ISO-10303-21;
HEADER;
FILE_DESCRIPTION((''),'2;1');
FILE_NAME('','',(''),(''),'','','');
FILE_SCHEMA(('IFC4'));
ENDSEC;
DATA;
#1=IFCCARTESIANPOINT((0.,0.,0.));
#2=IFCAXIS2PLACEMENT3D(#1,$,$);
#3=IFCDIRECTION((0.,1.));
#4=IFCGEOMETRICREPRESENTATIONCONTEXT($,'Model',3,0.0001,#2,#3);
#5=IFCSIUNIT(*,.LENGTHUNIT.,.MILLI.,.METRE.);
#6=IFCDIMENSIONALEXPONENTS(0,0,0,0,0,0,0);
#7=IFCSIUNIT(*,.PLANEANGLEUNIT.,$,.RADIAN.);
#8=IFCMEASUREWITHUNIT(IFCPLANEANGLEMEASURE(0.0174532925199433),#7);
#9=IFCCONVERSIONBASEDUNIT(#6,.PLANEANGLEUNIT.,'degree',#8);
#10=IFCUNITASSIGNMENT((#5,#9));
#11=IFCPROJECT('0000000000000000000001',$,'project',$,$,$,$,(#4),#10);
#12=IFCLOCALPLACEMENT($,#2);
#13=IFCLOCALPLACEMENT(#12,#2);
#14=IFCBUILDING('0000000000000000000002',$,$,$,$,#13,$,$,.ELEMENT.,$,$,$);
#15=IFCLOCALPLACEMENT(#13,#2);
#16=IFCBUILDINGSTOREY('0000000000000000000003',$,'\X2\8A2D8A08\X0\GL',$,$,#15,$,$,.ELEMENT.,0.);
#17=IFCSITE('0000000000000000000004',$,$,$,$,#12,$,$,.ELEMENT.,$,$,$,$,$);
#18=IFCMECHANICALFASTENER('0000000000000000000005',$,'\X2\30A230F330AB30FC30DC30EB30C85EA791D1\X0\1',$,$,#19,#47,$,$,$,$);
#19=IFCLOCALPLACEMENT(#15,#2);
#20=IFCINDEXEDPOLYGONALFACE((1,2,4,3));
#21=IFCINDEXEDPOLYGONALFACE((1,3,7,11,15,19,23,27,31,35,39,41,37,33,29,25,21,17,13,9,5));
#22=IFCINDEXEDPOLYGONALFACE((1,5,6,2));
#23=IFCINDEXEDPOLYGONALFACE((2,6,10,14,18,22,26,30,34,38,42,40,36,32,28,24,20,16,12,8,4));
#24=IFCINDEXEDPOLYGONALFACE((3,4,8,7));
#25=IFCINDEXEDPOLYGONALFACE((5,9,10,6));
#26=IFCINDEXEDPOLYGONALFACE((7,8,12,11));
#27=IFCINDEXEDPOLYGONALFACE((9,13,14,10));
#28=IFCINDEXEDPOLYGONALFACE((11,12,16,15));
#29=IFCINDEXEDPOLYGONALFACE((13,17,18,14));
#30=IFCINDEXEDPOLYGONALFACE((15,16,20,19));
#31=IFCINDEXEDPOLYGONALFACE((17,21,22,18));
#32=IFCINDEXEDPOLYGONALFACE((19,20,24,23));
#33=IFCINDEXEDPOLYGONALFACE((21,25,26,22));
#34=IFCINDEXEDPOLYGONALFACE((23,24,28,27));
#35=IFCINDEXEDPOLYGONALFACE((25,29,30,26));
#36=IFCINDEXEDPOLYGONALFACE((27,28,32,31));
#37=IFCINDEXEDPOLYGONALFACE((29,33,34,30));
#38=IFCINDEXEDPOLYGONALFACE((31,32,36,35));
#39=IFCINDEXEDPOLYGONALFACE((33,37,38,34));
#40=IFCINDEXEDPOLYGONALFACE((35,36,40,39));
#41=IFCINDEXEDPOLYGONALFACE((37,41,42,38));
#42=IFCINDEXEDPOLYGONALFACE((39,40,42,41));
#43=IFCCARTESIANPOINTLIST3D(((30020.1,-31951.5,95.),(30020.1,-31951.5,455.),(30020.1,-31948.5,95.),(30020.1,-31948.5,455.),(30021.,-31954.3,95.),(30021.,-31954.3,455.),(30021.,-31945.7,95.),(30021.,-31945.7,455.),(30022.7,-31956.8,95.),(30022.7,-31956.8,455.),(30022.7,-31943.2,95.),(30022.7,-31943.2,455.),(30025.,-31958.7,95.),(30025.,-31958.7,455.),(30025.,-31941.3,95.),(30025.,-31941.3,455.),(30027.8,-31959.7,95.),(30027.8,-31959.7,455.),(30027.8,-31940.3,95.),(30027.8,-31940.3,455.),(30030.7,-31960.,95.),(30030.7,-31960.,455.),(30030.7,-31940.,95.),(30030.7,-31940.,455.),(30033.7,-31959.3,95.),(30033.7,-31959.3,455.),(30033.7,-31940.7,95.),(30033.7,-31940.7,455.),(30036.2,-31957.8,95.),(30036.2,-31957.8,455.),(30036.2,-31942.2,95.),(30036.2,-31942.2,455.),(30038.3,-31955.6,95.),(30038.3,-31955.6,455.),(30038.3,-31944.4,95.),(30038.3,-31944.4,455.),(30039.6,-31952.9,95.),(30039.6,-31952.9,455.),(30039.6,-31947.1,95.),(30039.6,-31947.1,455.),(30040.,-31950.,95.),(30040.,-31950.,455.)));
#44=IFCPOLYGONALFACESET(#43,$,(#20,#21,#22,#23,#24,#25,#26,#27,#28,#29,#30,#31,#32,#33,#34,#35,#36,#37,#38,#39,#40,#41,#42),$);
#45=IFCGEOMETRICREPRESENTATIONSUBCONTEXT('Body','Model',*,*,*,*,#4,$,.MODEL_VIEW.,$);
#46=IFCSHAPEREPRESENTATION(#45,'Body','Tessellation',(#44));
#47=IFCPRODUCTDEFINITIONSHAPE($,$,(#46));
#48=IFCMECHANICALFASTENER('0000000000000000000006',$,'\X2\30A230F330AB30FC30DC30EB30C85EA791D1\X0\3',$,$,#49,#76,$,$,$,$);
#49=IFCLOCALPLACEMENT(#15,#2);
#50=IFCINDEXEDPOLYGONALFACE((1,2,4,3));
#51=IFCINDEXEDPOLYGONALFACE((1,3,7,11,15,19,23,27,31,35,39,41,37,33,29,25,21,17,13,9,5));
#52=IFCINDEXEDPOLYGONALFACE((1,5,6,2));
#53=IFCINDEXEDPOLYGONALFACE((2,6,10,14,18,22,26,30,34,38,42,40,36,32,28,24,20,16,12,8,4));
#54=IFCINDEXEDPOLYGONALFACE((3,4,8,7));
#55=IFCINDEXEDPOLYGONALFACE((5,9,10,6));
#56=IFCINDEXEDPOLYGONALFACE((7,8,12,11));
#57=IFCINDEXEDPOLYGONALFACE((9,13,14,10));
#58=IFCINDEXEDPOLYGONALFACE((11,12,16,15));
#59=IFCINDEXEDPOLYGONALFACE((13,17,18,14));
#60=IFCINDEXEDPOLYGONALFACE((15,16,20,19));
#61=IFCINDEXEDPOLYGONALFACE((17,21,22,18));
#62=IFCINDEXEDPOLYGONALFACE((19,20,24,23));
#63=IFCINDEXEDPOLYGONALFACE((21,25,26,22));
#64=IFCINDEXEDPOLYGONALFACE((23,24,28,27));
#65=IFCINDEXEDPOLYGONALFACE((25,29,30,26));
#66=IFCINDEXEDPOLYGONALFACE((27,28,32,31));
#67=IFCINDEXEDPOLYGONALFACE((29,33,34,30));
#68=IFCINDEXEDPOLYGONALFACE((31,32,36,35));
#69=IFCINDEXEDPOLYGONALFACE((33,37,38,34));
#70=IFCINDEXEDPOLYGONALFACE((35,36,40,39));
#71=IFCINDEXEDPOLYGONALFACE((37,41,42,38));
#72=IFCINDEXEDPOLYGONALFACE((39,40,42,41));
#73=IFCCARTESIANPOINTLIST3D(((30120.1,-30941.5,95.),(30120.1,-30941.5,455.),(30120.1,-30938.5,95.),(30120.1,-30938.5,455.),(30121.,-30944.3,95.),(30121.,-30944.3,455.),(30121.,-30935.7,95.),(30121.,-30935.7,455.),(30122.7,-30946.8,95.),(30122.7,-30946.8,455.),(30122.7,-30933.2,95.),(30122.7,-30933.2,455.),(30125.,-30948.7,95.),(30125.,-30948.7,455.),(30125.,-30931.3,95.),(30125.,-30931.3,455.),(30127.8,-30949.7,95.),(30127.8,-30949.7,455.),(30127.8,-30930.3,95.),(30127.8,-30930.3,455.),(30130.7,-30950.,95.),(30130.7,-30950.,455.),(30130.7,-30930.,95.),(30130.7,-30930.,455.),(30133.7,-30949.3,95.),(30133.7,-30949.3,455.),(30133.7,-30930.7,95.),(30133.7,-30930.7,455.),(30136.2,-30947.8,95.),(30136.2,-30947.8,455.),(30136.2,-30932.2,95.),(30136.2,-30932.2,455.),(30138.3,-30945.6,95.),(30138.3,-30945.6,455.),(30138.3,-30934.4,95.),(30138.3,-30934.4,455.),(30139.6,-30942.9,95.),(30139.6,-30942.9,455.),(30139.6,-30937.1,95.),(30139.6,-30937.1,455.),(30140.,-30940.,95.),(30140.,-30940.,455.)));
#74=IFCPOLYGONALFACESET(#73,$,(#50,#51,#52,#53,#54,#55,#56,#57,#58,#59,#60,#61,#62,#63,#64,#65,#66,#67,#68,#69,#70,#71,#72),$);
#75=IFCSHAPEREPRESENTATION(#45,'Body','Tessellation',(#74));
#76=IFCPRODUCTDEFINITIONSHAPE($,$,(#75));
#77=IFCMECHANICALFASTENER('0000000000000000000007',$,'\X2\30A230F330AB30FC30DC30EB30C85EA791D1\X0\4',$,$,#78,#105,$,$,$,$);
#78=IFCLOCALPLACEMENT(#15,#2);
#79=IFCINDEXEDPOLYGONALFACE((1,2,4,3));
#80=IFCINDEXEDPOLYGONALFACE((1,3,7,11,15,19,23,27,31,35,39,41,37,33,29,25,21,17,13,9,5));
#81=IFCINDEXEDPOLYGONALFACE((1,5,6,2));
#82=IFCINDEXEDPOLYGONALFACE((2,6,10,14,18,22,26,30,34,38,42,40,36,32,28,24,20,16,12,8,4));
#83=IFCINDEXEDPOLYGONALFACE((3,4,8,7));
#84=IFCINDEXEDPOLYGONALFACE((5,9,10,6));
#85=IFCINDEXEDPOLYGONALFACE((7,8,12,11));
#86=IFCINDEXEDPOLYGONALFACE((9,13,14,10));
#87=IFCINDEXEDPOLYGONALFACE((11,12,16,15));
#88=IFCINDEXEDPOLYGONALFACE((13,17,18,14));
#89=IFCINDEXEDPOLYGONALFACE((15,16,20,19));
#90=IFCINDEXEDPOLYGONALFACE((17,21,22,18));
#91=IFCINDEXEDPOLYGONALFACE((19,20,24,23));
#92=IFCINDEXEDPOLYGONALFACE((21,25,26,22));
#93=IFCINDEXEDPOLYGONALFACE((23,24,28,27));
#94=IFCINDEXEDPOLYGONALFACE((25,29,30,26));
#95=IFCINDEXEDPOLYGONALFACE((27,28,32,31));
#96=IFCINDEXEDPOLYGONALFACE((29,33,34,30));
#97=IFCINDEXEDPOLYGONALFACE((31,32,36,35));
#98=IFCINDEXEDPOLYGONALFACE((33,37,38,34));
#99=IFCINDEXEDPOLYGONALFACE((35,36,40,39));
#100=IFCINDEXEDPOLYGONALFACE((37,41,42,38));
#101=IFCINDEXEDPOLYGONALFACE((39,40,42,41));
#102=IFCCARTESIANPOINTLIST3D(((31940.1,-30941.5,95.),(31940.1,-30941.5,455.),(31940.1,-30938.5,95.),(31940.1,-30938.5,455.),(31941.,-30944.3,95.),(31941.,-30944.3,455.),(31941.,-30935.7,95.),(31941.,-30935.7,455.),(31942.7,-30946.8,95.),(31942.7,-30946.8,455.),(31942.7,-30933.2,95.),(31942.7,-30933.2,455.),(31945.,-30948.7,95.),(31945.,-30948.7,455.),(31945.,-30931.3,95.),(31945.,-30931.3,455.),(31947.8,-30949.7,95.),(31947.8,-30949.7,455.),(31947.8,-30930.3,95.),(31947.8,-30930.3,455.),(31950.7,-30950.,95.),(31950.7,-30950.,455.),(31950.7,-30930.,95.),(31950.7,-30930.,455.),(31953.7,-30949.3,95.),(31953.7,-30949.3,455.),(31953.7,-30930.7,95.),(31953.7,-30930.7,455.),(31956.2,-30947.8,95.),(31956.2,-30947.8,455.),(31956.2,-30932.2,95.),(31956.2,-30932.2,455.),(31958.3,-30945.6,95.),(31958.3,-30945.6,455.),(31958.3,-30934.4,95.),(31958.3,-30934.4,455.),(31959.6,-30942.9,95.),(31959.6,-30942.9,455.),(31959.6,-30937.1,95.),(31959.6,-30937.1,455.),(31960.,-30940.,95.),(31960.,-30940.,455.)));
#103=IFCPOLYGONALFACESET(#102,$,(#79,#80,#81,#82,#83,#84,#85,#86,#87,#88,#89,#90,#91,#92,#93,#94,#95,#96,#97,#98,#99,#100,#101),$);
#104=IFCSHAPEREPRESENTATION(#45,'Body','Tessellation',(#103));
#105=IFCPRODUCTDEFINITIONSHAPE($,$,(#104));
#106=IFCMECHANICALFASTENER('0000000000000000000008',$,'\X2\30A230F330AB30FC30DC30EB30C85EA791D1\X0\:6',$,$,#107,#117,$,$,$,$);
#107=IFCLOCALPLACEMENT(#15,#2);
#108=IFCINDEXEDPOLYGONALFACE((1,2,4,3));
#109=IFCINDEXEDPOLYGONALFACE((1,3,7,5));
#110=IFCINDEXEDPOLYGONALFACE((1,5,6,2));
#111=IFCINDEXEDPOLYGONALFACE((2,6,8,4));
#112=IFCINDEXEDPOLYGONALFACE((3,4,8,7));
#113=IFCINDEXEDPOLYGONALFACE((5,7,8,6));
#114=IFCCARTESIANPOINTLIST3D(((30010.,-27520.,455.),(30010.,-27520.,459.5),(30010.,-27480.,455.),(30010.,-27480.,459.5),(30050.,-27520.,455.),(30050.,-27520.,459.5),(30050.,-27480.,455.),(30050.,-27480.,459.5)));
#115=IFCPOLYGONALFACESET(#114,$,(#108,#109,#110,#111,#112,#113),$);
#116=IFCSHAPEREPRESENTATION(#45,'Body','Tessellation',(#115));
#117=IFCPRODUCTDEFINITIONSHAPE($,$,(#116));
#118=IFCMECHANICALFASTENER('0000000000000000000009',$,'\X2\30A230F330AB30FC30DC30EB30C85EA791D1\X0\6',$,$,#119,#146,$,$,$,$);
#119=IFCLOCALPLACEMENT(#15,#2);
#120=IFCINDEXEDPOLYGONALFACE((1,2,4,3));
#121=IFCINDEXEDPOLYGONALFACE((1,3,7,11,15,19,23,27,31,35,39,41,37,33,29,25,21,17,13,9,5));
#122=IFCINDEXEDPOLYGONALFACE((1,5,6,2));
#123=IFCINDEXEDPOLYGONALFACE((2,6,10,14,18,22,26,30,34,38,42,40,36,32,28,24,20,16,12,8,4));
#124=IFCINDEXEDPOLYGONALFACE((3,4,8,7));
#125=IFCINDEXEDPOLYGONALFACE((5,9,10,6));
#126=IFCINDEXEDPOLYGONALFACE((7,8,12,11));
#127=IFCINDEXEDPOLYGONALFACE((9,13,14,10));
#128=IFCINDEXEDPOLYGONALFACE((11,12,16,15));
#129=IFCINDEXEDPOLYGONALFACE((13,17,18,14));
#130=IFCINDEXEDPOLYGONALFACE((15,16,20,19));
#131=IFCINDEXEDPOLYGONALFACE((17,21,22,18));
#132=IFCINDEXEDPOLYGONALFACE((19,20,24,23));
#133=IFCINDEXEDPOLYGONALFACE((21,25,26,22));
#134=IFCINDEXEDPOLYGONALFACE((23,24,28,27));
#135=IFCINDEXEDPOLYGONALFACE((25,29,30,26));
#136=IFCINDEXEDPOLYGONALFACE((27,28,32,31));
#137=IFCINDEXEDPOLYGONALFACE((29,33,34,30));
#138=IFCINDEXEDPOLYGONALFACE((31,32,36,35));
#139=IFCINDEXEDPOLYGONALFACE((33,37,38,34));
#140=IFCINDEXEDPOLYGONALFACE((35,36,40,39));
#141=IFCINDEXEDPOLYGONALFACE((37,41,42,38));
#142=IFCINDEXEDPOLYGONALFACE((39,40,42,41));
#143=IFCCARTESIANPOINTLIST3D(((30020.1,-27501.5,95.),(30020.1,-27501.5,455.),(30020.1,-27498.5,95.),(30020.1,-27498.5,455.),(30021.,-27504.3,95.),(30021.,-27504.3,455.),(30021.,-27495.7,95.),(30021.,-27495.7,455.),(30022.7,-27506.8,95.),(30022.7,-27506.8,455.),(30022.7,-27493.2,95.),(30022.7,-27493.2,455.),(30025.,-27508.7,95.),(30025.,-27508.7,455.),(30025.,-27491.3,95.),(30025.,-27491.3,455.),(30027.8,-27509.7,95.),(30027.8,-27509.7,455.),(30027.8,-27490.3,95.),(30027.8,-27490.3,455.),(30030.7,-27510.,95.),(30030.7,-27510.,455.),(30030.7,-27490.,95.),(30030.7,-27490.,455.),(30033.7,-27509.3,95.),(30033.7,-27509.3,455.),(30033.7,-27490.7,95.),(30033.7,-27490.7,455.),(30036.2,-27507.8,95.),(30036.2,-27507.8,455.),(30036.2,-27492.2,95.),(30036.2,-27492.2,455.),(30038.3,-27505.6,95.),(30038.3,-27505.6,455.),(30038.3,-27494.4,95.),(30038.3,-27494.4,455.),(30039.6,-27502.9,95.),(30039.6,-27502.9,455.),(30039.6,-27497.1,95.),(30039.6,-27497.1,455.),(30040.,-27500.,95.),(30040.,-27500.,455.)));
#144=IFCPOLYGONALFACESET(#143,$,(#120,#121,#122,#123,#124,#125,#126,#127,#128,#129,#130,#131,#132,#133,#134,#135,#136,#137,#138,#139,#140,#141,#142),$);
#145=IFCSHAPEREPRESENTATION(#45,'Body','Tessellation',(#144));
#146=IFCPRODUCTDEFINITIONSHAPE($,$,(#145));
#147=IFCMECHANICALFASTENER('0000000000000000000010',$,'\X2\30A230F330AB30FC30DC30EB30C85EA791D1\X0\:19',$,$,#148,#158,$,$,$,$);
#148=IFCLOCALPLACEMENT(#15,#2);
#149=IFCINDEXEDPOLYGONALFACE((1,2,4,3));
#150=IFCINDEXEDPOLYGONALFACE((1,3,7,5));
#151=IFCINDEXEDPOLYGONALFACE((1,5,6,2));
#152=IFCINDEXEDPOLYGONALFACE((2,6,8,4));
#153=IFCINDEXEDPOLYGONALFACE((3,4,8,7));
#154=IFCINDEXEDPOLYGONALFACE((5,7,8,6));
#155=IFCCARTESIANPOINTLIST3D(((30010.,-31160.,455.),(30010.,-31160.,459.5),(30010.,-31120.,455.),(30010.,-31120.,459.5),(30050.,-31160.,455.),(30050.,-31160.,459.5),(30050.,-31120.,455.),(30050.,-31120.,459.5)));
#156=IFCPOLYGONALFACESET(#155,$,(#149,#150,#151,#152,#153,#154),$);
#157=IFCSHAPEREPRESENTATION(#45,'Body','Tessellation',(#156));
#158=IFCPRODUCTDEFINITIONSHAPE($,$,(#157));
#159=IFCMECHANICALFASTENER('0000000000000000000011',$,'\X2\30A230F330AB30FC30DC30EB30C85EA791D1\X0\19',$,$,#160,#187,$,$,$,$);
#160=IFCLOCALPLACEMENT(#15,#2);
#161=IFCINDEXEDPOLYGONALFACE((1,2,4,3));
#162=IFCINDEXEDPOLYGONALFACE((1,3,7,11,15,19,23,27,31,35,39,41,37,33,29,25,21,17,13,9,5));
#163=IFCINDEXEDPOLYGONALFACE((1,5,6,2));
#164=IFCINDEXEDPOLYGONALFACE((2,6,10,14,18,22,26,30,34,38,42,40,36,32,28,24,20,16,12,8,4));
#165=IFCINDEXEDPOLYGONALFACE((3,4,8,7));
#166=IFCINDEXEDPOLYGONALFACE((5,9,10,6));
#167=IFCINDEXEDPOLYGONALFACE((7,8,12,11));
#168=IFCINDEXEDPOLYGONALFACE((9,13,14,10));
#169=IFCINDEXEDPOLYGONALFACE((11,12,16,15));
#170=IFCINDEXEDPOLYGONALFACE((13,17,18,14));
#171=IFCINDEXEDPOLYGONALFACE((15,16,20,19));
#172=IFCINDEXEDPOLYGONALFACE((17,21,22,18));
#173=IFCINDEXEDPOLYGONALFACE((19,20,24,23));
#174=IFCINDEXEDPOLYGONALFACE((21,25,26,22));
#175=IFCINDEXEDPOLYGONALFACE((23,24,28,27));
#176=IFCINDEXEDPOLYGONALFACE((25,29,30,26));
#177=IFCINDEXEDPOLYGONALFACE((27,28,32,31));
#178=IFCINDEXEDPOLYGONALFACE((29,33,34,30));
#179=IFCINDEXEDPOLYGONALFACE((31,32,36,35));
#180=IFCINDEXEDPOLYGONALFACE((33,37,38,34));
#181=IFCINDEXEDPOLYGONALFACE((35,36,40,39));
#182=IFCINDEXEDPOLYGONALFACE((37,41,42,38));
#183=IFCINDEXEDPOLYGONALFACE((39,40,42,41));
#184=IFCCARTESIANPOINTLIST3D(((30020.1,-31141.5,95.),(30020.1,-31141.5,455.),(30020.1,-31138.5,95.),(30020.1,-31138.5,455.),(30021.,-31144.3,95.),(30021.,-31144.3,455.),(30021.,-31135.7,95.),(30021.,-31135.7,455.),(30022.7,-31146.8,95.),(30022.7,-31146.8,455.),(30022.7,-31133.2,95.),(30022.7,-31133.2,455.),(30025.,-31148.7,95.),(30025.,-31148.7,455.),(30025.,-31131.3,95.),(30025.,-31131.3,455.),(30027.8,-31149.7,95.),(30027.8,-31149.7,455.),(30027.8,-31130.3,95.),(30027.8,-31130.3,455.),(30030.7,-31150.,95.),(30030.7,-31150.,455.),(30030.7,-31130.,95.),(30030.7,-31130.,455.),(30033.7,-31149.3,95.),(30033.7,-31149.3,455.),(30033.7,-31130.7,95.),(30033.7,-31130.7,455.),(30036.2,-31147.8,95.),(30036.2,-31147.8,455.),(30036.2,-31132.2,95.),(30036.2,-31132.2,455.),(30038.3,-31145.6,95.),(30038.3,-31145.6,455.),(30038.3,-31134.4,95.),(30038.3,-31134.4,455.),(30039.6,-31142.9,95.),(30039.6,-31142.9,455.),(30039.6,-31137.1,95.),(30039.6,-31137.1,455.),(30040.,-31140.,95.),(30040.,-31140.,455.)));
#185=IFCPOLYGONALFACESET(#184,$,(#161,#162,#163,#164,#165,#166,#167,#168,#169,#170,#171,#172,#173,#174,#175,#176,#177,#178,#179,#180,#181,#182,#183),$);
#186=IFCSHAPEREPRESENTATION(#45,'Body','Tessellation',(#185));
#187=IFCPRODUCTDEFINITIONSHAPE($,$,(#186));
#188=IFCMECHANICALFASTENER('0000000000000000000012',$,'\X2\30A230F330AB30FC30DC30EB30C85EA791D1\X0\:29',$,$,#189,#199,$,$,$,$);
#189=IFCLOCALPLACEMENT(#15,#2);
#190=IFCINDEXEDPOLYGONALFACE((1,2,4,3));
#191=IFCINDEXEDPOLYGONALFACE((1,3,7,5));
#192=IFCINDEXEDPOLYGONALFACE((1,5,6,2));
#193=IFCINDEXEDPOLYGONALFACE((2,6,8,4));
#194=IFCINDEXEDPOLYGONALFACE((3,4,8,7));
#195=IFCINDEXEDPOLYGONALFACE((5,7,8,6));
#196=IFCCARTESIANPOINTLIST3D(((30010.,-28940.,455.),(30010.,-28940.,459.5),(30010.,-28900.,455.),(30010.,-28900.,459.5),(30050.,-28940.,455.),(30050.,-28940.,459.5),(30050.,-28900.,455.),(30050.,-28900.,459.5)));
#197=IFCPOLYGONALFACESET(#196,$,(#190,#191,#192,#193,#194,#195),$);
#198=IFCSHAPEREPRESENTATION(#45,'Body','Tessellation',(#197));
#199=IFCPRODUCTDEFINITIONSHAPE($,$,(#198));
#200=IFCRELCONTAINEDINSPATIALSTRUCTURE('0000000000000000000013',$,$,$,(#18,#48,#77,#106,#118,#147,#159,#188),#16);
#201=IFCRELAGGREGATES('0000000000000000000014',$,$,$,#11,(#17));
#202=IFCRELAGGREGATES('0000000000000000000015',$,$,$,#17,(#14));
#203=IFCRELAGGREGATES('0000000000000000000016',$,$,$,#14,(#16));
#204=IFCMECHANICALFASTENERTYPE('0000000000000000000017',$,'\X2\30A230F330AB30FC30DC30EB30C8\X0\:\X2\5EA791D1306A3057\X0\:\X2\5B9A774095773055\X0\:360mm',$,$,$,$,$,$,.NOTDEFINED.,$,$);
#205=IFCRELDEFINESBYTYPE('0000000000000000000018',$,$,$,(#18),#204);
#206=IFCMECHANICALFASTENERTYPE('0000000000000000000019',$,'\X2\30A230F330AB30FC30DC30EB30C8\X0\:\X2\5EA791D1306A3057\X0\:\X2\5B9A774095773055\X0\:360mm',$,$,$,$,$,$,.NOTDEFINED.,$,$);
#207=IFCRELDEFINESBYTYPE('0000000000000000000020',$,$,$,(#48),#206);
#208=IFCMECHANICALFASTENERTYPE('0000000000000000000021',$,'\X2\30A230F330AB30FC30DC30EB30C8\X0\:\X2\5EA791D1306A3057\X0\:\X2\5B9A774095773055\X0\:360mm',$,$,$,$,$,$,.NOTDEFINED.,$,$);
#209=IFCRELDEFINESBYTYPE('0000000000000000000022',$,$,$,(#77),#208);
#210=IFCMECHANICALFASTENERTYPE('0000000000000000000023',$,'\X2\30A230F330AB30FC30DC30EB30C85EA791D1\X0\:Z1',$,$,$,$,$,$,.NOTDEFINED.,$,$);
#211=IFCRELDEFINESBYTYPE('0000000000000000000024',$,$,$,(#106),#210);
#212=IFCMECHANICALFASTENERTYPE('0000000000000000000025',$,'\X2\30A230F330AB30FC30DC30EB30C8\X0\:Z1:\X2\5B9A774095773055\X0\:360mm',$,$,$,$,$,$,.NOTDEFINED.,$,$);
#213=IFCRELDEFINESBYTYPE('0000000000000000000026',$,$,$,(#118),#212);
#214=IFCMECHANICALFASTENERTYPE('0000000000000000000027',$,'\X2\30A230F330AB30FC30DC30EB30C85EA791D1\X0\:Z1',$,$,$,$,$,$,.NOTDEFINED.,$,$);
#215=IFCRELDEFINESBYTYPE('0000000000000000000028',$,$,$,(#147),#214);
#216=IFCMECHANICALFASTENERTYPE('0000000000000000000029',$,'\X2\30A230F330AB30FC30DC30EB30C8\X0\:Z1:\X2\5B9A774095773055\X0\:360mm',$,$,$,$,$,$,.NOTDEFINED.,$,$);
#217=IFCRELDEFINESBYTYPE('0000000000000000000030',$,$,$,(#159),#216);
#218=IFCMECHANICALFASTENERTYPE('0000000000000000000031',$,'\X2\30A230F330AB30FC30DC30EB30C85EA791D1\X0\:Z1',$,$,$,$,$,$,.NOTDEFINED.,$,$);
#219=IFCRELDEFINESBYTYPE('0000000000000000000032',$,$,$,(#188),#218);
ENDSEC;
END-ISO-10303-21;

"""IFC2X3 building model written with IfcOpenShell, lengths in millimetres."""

from ifc_helpers import new_model, entity, si_unit, converted_unit, direction, frame, origin, origin_with_axes, origin_2d, place, context, subcontext, project, spatial, rectangle, circle, extrude, type_object, element, save


model = new_model("IFC2X3")

# Units and contexts
model_context = context("Model", 3, precision=0.0001, world=origin(), true_north=direction((0.0, 1.0)))
body_context = subcontext(model_context, "Body", "Model", "MODEL_VIEW")
ifc_project = project(units=[si_unit("LENGTHUNIT", "METRE", prefix="MILLI"), converted_unit("PLANEANGLEUNIT", "degree", entity("IfcPlaneAngleMeasure", 0.0174532925199433), si_unit("PLANEANGLEUNIT", "RADIAN"), dimensions=[0, 0, 0, 0, 0, 0, 0])], contexts=[model_context])

# Site, building, storey
site_placement = place(None, origin())
site = spatial("IfcSite", under=ifc_project, at=site_placement, CompositionType="ELEMENT")
building_placement = place(site_placement, origin())
building = spatial("IfcBuilding", under=site, at=building_placement, CompositionType="ELEMENT")
storey_placement = place(building_placement, origin())
storey = spatial("IfcBuildingStorey", under=building, at=storey_placement, Name="設計GL", CompositionType="ELEMENT", Elevation=0.0)

# Mechanical fasteners
mechanical_fastener_type_1 = type_object("IfcMechanicalFastenerType", Name="アンカーボルト:座金なし:定着長さ:360mm")
mechanical_fastener_1_placement = place(storey_placement, frame((30030.0, -31950.0, 95.0)))
element("IfcMechanicalFastener", 1, at=mechanical_fastener_1_placement, inside=storey, type_object=mechanical_fastener_type_1, Name="アンカーボルト座金1", context=body_context, shape_type="SweptSolid", body=[
    extrude(circle(Radius=10.0, at=origin_2d()), origin_with_axes(), (0.0, 0.0, 1.0), 360.0),
])
mechanical_fastener_type_2 = type_object("IfcMechanicalFastenerType", Name="アンカーボルト:座金なし:定着長さ:360mm")
mechanical_fastener_2_placement = place(storey_placement, frame((30130.0, -30940.0, 95.0)))
element("IfcMechanicalFastener", 2, at=mechanical_fastener_2_placement, inside=storey, type_object=mechanical_fastener_type_2, Name="アンカーボルト座金3", context=body_context, shape_type="SweptSolid", body=[
    extrude(circle(Radius=10.0, at=origin_2d()), origin_with_axes(), (0.0, 0.0, 1.0), 360.0),
])
mechanical_fastener_type_3 = type_object("IfcMechanicalFastenerType", Name="アンカーボルト:座金なし:定着長さ:360mm")
mechanical_fastener_3_placement = place(storey_placement, frame((31950.0, -30940.0, 95.0)))
element("IfcMechanicalFastener", 3, at=mechanical_fastener_3_placement, inside=storey, type_object=mechanical_fastener_type_3, Name="アンカーボルト座金4", context=body_context, shape_type="SweptSolid", body=[
    extrude(circle(Radius=10.0, at=origin_2d()), origin_with_axes(), (0.0, 0.0, 1.0), 360.0),
])
mechanical_fastener_type_4 = type_object("IfcMechanicalFastenerType", Name="アンカーボルト座金:Z1")
mechanical_fastener_4_placement = place(storey_placement, frame((30030.0, -27500.0, 455.0)))
element("IfcMechanicalFastener", 4, at=mechanical_fastener_4_placement, inside=storey, type_object=mechanical_fastener_type_4, Name="アンカーボルト座金:6", context=body_context, shape_type="SweptSolid", body=[
    extrude(rectangle(XDim=40.0, YDim=40.0, at=origin_2d()), origin_with_axes(), (0.0, 0.0, 1.0), 4.5),
])
mechanical_fastener_type_5 = type_object("IfcMechanicalFastenerType", Name="アンカーボルト:Z1:定着長さ:360mm")
mechanical_fastener_5_placement = place(storey_placement, frame((30030.0, -27500.0, 95.0)))
element("IfcMechanicalFastener", 5, at=mechanical_fastener_5_placement, inside=storey, type_object=mechanical_fastener_type_5, Name="アンカーボルト座金6", context=body_context, shape_type="SweptSolid", body=[
    extrude(circle(Radius=10.0, at=origin_2d()), origin_with_axes(), (0.0, 0.0, 1.0), 360.0),
])
mechanical_fastener_type_6 = type_object("IfcMechanicalFastenerType", Name="アンカーボルト座金:Z1")
mechanical_fastener_6_placement = place(storey_placement, frame((30030.0, -31140.0, 455.0)))
element("IfcMechanicalFastener", 6, at=mechanical_fastener_6_placement, inside=storey, type_object=mechanical_fastener_type_6, Name="アンカーボルト座金:19", context=body_context, shape_type="SweptSolid", body=[
    extrude(rectangle(XDim=40.0, YDim=40.0, at=origin_2d()), origin_with_axes(), (0.0, 0.0, 1.0), 4.5),
])
mechanical_fastener_type_7 = type_object("IfcMechanicalFastenerType", Name="アンカーボルト:Z1:定着長さ:360mm")
mechanical_fastener_7_placement = place(storey_placement, frame((30030.0, -31140.0, 95.0)))
element("IfcMechanicalFastener", 7, at=mechanical_fastener_7_placement, inside=storey, type_object=mechanical_fastener_type_7, Name="アンカーボルト座金19", context=body_context, shape_type="SweptSolid", body=[
    extrude(circle(Radius=10.0, at=origin_2d()), origin_with_axes(), (0.0, 0.0, 1.0), 360.0),
])
mechanical_fastener_type_8 = type_object("IfcMechanicalFastenerType", Name="アンカーボルト座金:Z1")
mechanical_fastener_8_placement = place(storey_placement, frame((30030.0, -28920.0, 455.0)))
element("IfcMechanicalFastener", 8, at=mechanical_fastener_8_placement, inside=storey, type_object=mechanical_fastener_type_8, Name="アンカーボルト座金:29", context=body_context, shape_type="SweptSolid", body=[
    extrude(rectangle(XDim=40.0, YDim=40.0, at=origin_2d()), origin_with_axes(), (0.0, 0.0, 1.0), 4.5),
])

save(model, "model.ifc")
